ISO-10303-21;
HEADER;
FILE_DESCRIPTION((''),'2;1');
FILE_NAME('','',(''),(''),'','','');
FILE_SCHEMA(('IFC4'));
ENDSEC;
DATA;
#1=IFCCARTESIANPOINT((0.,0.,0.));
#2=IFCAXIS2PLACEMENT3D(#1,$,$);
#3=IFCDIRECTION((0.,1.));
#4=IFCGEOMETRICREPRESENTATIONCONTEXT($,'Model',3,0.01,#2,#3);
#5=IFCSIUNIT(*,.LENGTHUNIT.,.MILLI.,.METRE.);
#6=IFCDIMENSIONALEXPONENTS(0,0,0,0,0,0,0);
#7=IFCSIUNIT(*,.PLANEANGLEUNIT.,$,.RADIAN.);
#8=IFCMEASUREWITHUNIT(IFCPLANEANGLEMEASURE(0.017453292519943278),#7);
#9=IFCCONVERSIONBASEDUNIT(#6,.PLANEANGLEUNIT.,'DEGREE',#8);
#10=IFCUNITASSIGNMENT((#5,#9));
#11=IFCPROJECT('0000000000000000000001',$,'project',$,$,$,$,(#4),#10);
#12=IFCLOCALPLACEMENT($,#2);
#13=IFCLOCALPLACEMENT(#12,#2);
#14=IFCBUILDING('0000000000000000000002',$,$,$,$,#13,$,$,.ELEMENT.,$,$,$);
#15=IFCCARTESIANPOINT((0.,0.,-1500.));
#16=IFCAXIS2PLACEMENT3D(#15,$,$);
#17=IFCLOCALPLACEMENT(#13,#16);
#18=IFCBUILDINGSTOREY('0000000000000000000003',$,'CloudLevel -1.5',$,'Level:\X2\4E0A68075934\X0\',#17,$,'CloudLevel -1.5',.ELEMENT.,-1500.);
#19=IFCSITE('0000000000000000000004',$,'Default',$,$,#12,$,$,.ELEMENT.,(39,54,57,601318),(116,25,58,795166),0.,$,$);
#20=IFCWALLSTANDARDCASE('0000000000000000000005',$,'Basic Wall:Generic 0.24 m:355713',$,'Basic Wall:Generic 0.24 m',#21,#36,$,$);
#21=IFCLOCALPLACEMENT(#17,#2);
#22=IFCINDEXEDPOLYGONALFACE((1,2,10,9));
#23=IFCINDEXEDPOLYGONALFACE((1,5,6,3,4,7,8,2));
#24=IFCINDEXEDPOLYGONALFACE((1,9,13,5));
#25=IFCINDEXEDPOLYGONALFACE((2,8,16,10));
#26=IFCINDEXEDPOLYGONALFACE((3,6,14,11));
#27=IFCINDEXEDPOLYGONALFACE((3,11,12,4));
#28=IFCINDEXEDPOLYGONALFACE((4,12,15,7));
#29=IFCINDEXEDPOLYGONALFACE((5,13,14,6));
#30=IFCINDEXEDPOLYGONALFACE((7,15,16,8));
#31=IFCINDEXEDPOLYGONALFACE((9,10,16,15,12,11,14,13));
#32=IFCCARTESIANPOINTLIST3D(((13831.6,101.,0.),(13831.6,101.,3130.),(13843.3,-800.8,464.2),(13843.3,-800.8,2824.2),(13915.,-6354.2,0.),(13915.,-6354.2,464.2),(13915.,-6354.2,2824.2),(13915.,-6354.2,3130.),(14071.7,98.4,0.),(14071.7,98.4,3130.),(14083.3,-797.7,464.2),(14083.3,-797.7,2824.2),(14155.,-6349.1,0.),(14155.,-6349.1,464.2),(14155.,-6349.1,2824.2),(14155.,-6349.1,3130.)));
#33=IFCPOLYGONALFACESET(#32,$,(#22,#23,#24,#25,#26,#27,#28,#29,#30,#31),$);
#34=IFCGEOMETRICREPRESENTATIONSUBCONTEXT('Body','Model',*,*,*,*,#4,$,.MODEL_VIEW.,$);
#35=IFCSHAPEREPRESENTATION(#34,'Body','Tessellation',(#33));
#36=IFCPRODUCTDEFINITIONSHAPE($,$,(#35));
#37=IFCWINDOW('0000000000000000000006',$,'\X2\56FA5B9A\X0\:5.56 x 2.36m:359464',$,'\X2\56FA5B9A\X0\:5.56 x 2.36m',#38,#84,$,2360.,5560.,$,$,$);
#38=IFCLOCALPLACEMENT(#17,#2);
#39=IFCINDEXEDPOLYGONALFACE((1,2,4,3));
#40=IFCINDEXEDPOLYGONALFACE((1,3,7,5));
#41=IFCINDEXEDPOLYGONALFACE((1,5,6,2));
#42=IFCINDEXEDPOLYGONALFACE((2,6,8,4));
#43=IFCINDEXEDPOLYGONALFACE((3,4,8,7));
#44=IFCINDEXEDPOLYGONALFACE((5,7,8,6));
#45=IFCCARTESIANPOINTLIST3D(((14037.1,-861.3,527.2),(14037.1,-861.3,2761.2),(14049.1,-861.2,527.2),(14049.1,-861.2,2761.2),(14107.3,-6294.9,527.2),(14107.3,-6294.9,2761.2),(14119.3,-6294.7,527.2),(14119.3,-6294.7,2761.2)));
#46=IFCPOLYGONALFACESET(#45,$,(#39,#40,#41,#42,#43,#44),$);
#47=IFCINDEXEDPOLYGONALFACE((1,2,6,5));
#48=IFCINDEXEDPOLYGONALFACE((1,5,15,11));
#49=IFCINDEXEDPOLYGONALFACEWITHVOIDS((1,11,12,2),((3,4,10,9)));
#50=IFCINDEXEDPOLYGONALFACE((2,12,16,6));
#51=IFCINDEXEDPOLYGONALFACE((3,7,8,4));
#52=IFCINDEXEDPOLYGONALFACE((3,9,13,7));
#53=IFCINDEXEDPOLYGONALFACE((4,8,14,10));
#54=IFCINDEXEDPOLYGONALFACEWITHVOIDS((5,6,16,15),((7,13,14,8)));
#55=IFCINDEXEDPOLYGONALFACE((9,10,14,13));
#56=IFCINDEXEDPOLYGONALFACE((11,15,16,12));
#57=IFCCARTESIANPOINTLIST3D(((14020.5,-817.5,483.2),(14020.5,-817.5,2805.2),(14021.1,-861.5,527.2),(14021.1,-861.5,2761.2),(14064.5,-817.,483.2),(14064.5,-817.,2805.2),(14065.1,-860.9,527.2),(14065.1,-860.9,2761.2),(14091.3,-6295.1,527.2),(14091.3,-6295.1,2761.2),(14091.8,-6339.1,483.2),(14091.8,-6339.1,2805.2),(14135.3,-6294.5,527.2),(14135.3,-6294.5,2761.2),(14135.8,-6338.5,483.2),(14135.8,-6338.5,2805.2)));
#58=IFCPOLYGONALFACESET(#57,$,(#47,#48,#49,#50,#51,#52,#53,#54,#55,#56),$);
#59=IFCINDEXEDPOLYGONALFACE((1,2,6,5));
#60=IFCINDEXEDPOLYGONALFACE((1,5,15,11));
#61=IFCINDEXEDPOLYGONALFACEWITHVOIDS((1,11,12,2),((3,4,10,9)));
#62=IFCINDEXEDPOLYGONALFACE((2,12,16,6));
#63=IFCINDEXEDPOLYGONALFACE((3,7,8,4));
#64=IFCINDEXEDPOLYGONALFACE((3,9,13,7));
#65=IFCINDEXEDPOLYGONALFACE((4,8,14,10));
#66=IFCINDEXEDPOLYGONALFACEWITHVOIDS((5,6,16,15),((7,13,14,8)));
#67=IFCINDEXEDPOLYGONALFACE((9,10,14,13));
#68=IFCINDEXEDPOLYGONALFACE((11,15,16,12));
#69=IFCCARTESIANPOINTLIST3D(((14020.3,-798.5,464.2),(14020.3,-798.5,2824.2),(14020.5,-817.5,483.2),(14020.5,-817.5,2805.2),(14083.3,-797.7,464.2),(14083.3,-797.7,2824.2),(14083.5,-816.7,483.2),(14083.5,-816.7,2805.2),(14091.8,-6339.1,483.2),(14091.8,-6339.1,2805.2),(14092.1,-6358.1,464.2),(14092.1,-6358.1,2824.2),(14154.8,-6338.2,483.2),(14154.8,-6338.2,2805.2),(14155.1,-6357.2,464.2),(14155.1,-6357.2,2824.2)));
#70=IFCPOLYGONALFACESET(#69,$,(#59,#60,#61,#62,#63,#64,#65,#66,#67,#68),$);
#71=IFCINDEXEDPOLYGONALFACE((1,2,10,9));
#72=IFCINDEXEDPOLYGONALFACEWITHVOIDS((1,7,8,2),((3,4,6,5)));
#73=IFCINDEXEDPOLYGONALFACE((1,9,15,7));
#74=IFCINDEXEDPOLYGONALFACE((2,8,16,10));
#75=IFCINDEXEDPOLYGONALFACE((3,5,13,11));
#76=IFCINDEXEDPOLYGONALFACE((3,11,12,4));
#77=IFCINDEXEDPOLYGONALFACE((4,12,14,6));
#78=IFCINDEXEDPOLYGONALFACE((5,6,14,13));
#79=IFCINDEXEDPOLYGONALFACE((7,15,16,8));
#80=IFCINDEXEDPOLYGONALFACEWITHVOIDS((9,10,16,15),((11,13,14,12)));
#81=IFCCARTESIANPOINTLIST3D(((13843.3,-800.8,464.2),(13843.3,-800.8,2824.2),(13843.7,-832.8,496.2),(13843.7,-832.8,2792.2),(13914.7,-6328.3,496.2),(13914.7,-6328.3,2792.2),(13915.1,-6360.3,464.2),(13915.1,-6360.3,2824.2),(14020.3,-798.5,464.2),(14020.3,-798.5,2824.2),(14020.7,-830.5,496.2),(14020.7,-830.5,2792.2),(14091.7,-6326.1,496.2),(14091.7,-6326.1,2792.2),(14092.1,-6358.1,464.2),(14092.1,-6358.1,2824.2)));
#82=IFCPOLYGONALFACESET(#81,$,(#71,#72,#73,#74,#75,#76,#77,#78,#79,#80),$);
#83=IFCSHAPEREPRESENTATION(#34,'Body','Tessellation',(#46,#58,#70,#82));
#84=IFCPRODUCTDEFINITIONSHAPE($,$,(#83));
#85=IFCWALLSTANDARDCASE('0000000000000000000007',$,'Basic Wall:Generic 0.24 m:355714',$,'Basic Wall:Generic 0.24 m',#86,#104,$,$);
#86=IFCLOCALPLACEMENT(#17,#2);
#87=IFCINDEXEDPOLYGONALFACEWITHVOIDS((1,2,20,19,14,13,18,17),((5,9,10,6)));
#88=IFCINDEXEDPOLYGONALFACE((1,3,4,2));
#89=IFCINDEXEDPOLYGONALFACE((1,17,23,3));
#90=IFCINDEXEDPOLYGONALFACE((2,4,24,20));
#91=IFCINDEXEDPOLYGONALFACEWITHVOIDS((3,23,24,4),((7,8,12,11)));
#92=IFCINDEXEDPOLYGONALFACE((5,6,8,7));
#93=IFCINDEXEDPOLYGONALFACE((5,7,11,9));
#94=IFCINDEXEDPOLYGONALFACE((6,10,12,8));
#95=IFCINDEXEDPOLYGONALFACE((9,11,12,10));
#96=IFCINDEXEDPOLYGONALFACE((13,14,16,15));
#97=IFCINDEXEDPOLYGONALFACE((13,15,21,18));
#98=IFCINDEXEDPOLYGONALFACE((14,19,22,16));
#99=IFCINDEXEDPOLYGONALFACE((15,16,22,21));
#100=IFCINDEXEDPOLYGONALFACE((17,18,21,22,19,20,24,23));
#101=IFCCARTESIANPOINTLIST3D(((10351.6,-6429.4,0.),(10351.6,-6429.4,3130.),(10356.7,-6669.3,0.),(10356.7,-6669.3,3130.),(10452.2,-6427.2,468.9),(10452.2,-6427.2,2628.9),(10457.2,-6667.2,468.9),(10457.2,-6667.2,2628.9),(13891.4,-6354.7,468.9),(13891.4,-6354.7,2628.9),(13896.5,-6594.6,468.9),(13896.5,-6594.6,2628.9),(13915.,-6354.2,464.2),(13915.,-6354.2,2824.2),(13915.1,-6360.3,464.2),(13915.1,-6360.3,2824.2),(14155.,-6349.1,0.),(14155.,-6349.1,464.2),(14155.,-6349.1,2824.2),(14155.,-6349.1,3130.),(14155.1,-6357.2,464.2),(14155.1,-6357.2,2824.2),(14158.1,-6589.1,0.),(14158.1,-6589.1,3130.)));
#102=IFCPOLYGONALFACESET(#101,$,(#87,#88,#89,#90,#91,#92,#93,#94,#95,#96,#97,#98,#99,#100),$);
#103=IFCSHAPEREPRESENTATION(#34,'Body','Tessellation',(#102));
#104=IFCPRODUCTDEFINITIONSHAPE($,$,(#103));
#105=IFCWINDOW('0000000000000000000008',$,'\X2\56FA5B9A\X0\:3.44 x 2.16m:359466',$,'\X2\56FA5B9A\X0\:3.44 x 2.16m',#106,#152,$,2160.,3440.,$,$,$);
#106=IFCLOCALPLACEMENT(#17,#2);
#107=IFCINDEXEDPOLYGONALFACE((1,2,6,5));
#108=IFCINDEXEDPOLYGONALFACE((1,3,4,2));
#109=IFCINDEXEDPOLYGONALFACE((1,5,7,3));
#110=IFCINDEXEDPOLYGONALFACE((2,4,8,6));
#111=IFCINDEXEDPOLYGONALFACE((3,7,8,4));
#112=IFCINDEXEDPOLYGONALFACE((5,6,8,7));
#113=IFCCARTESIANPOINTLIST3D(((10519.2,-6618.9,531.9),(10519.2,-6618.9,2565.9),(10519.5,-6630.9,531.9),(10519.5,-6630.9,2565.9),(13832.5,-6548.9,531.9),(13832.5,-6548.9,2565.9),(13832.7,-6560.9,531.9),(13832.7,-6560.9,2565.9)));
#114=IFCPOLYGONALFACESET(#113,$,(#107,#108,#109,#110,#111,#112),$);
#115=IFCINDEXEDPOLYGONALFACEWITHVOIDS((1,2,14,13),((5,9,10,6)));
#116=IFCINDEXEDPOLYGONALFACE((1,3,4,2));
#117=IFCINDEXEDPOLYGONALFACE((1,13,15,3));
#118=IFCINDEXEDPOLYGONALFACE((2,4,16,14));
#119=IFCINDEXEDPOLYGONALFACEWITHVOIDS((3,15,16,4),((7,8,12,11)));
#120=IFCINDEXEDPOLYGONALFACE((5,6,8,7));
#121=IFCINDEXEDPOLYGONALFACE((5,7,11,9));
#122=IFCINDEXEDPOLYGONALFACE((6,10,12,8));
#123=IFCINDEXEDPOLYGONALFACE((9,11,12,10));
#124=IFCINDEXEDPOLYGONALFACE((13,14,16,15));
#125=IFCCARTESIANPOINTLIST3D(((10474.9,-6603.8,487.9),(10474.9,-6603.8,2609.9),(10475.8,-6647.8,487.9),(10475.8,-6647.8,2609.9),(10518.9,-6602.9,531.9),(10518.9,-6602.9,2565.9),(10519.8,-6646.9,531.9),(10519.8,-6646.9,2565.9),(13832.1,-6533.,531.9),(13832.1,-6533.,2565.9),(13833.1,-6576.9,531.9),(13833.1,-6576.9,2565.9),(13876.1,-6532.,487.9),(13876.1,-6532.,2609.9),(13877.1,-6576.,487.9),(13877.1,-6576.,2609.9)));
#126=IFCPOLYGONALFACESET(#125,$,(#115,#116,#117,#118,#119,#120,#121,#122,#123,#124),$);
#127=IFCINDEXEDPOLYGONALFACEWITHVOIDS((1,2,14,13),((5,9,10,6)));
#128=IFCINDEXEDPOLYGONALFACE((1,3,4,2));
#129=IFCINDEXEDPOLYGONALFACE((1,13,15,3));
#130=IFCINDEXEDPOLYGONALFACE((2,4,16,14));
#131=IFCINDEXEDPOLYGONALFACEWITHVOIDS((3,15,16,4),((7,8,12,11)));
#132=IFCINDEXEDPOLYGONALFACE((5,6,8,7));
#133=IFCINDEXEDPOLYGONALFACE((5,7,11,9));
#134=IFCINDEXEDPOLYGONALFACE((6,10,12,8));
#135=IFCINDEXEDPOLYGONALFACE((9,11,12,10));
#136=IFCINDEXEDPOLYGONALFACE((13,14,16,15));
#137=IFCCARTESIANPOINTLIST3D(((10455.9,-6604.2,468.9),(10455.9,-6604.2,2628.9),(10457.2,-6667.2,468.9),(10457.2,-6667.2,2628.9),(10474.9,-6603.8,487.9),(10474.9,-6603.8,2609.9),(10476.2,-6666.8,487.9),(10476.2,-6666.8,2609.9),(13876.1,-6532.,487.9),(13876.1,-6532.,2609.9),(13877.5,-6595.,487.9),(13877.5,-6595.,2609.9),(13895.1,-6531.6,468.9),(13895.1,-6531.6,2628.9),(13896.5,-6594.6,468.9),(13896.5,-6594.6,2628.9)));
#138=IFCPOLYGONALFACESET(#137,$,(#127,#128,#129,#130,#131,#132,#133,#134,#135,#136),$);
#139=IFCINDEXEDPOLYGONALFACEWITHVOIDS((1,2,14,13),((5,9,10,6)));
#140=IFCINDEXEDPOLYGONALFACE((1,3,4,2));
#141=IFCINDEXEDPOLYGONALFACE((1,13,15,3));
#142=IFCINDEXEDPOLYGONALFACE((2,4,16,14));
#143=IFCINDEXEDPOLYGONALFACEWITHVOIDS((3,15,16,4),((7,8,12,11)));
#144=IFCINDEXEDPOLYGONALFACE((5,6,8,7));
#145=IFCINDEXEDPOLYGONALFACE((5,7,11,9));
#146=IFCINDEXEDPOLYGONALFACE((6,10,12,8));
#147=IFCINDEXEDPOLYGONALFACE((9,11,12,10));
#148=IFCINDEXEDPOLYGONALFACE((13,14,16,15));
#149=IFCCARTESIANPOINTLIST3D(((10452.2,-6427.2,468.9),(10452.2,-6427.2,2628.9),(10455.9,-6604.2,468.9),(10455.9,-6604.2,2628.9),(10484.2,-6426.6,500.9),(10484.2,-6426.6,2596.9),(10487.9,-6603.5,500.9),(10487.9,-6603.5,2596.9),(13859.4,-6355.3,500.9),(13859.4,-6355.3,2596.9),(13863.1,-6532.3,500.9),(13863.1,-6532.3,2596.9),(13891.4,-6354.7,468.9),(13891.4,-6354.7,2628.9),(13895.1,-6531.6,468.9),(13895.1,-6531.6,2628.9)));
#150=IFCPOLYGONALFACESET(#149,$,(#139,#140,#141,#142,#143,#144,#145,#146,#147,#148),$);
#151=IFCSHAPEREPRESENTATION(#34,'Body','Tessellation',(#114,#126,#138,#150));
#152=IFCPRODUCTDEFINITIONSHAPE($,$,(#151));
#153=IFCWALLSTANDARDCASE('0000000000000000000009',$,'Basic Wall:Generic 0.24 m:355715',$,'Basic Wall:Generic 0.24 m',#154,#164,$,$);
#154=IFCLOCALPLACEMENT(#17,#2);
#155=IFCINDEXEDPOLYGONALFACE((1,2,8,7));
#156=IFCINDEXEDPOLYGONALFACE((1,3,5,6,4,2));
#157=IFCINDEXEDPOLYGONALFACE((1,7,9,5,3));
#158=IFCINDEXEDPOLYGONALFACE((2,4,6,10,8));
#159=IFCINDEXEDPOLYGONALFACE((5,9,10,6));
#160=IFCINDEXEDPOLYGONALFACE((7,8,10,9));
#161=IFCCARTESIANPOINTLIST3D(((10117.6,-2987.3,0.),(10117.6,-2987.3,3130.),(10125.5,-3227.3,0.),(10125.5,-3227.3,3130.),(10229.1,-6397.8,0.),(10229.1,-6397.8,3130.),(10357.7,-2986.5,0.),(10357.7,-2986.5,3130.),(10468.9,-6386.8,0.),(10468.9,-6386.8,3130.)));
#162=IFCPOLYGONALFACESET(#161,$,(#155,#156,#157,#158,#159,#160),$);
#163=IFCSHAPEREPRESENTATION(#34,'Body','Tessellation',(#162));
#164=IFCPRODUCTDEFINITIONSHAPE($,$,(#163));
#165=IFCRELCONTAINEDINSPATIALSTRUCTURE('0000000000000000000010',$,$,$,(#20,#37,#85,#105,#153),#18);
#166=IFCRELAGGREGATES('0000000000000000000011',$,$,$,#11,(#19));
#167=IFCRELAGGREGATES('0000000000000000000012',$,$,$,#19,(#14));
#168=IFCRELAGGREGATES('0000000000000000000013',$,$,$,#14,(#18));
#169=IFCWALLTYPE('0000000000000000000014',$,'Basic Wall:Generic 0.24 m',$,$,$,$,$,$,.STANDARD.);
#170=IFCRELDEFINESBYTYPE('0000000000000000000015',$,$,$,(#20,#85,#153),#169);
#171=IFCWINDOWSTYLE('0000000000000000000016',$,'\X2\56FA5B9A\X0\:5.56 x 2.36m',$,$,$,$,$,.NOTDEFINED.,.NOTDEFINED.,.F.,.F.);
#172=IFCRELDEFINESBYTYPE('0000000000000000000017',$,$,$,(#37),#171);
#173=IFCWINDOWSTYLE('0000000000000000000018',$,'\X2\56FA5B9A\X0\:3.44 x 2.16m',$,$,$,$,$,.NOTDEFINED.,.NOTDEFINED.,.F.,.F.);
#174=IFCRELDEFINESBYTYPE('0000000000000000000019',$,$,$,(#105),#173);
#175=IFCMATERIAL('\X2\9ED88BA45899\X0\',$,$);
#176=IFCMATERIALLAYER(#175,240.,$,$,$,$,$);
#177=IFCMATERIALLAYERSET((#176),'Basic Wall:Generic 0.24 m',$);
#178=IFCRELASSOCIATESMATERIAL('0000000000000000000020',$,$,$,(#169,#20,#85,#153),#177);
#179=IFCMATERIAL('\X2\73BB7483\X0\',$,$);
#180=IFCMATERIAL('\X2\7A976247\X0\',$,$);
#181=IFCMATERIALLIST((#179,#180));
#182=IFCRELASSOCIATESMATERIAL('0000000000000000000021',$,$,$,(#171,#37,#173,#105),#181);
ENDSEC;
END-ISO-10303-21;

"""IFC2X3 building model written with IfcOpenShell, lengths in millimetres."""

from ifc_helpers import new_model, entity, si_unit, converted_unit, direction, frame, frame_2d, origin, place, context, subcontext, project, spatial, polyline, rectangle, outline, extrude, source, transform, mapped, material, material_list, layer, layer_set, layer_usage, type_object, type_shapes, element, fill, save


model = new_model("IFC2X3")

# Units and contexts
model_context = context("Model", 3, precision=0.01, world=origin(), true_north=direction((0.0, 1.0)))
body_context = subcontext(model_context, "Body", "Model", "MODEL_VIEW")
ifc_project = project(units=[si_unit("LENGTHUNIT", "METRE", prefix="MILLI"), converted_unit("PLANEANGLEUNIT", "DEGREE", entity("IfcPlaneAngleMeasure", 0.017453292519943278), si_unit("PLANEANGLEUNIT", "RADIAN"), dimensions=[0, 0, 0, 0, 0, 0, 0])], contexts=[model_context])

# Site, building, storey
site_placement = place(None, origin())
site = spatial("IfcSite", under=ifc_project, at=site_placement, Name="Default", CompositionType="ELEMENT", RefLatitude=(39, 54, 57, 601318), RefLongitude=(116, 25, 58, 795166), RefElevation=0.0)
building_placement = place(site_placement, origin())
building = spatial("IfcBuilding", under=site, at=building_placement, CompositionType="ELEMENT")
storey_placement = place(building_placement, frame((0.0, 0.0, -1500.0)))
storey = spatial("IfcBuildingStorey", under=building, at=storey_placement, Name="CloudLevel -1.5", ObjectType="Level:上标头", LongName="CloudLevel -1.5", CompositionType="ELEMENT", Elevation=-1500.0)

# Shared definitions
ifc_material_1 = material(Name="默认墙")
ifc_layer_1 = layer(ifc_material_1, 240.0)
ifc_layer_set_1 = layer_set([ifc_layer_1], Name="Basic Wall:Generic 0.24 m")
ifc_layer_usage_1 = layer_usage(ifc_layer_set_1, "AXIS2", "NEGATIVE", 120.0)
wall_type_1 = type_object("IfcWallType", Name="Basic Wall:Generic 0.24 m", PredefinedType="STANDARD", material=ifc_layer_set_1)

# Shared definitions
ifc_material_2 = material(Name="玻璃")

# Wall, opening, window
wall_1_placement = place(storey_placement, frame((14035.0, -6352.6, 0.0), z_axis=(0.0, 0.0, 1.0), x_axis=(-0.012912, 0.999917, 0.0)))
wall_1 = element("IfcWallStandardCase", 1, at=wall_1_placement, inside=storey, type_object=wall_type_1, material=ifc_layer_usage_1, Name="Basic Wall:Generic 0.24 m:355713", ObjectType="Basic Wall:Generic 0.24 m", context=body_context, shape_type="SweptSolid", body=[
    extrude(outline(polyline([(6450.0, -120.0), (6455.7, 120.0), (6215.7, 120.0), (0.0, 120.0), (2.0, -120.0), (6450.0, -120.0)])), origin(), (0.0, 0.0, 1.0), 3130.0),
])
opening_1_placement = place(wall_1_placement, frame((5553.8, 120.0, 464.2)))
opening_1 = element("IfcOpeningElement", 2, at=opening_1_placement, cuts=wall_1, ObjectType="Opening", context=body_context, shape_type="SweptSolid", body=[
    extrude(rectangle(XDim=2360.0, YDim=5560.0, at=frame_2d((1180.0, 2780.0), x_axis=(1.0, 0.0))), frame((0.0, 0.0, 0.0), z_axis=(0.0, -1.0, 0.0), x_axis=(0.0, 0.0, 1.0)), (0.0, 0.0, 1.0), 240.0),
])
ifc_material_3 = material(Name="窗扇")
ifc_material_list_1 = material_list([ifc_material_2, ifc_material_3])
window_style_1 = type_object("IfcWindowStyle", Name="固定:5.56 x 2.36m", ConstructionType="NOTDEFINED", OperationType="NOTDEFINED", ParameterTakesPrecedence=False, Sizeable=False, material=ifc_material_list_1)
shared_shape_1 = source(origin(), body_context, "Body", "SweptSolid", [
    extrude(rectangle(XDim=5434.0, YDim=12.0, at=frame_2d((0.0, 0.0), x_axis=(1.0, 0.0))), frame((2780.0, 225.0, 63.0), z_axis=(0.0, 0.0, 1.0), x_axis=(-1.0, 0.0, 0.0)), (0.0, 0.0, 1.0), 2234.0),
    extrude(outline(polyline([(-2761.0, -1161.0), (2761.0, -1161.0), (2761.0, 1161.0), (-2761.0, 1161.0), (-2761.0, -1161.0)]), holes=[polyline([(-2717.0, -1117.0), (-2717.0, 1117.0), (2717.0, 1117.0), (2717.0, -1117.0), (-2717.0, -1117.0)])]), frame((2780.0, 247.0, 1180.0), z_axis=(0.0, -1.0, 0.0), x_axis=(-1.0, 0.0, 0.0)), (0.0, 0.0, 1.0), 44.0),
    extrude(outline(polyline([(-2780.0, -1180.0), (2780.0, -1180.0), (2780.0, 1180.0), (-2780.0, 1180.0), (-2780.0, -1180.0)]), holes=[polyline([(-2761.0, -1161.0), (-2761.0, 1161.0), (2761.0, 1161.0), (2761.0, -1161.0), (-2761.0, -1161.0)])]), frame((2780.0, 266.0, 1180.0), z_axis=(0.0, -1.0, 0.0), x_axis=(-1.0, 0.0, 0.0)), (0.0, 0.0, 1.0), 63.0),
    extrude(outline(polyline([(-2780.0, -1180.0), (2780.0, -1180.0), (2780.0, 1180.0), (-2780.0, 1180.0), (-2780.0, -1180.0)]), holes=[polyline([(-2748.0, -1148.0), (-2748.0, 1148.0), (2748.0, 1148.0), (2748.0, -1148.0), (-2748.0, -1148.0)])]), frame((2780.0, 203.0, 1180.0), z_axis=(0.0, -1.0, 0.0), x_axis=(-1.0, 0.0, 0.0)), (0.0, 0.0, 1.0), 177.0),
])
type_shapes(window_style_1, [shared_shape_1])
window_1_placement = place(opening_1_placement, frame((0.0, 26.0, 0.0), z_axis=(0.0, 0.0, 1.0), x_axis=(-1.0, 0.0, 0.0)))
window_1 = element("IfcWindow", 3, at=window_1_placement, inside=storey, type_object=window_style_1, material=ifc_material_list_1, Name="固定:5.56 x 2.36m:359464", ObjectType="固定:5.56 x 2.36m", OverallHeight=2360.0, OverallWidth=5560.0, context=body_context, shape_type="MappedRepresentation", body=[
    mapped(shared_shape_1, transform((0.0, 0.0, 0.0), scale=1.0)),
])
fill(opening_1, window_1)

# Wall, openings, window
wall_2_placement = place(storey_placement, frame((10354.1, -6549.3, 0.0), z_axis=(0.0, 0.0, 1.0), x_axis=(0.999777, 0.0211, 0.0)))
wall_2 = element("IfcWallStandardCase", 4, at=wall_2_placement, inside=storey, type_object=wall_type_1, material=ifc_layer_usage_1, Name="Basic Wall:Generic 0.24 m:355714", ObjectType="Basic Wall:Generic 0.24 m", context=body_context, shape_type="SweptSolid", body=[
    extrude(outline(polyline([(3802.2, -120.0), (3804.2, 120.0), (3564.2, 120.0), (118.6, 120.0), (0.0, 120.0), (0.0, -82.9), (0.0, -120.0), (3802.2, -120.0)])), origin(), (0.0, 0.0, 1.0), 3130.0),
])
opening_2_placement = place(wall_2_placement, origin())
element("IfcOpeningElement", 5, at=opening_2_placement, cuts=wall_2, ObjectType="Opening", context=body_context, shape_type="SweptSolid", body=[
    extrude(rectangle(XDim=2360.0, YDim=240.0, at=frame_2d((0.0, 0.0), x_axis=(0.0, 1.0))), frame((3684.1, 112.8, 1644.2), z_axis=(0.008189, 0.999966, 0.0), x_axis=(0.999966, -0.008189, 0.0)), (0.0, 0.0, 1.0), 5560.0),
])
opening_3_placement = place(wall_2_placement, frame((3540.6, 120.0, 468.9)))
opening_3 = element("IfcOpeningElement", 6, at=opening_3_placement, cuts=wall_2, ObjectType="Opening", context=body_context, shape_type="SweptSolid", body=[
    extrude(rectangle(XDim=2160.0, YDim=3440.0, at=frame_2d((1080.0, 1720.0), x_axis=(1.0, 0.0))), frame((0.0, 0.0, 0.0), z_axis=(0.0, -1.0, 0.0), x_axis=(0.0, 0.0, 1.0)), (0.0, 0.0, 1.0), 240.0),
])
window_style_2 = type_object("IfcWindowStyle", Name="固定:3.44 x 2.16m", ConstructionType="NOTDEFINED", OperationType="NOTDEFINED", ParameterTakesPrecedence=False, Sizeable=False, material=ifc_material_list_1)
shared_shape_2 = source(origin(), body_context, "Body", "SweptSolid", [
    extrude(rectangle(XDim=3314.0, YDim=12.0, at=frame_2d((0.0, 0.0), x_axis=(1.0, 0.0))), frame((1720.0, 225.0, 63.0), z_axis=(0.0, 0.0, 1.0), x_axis=(-1.0, 0.0, 0.0)), (0.0, 0.0, 1.0), 2034.0),
    extrude(outline(polyline([(-1701.0, -1061.0), (1701.0, -1061.0), (1701.0, 1061.0), (-1701.0, 1061.0), (-1701.0, -1061.0)]), holes=[polyline([(-1657.0, -1017.0), (-1657.0, 1017.0), (1657.0, 1017.0), (1657.0, -1017.0), (-1657.0, -1017.0)])]), frame((1720.0, 247.0, 1080.0), z_axis=(0.0, -1.0, 0.0), x_axis=(-1.0, 0.0, 0.0)), (0.0, 0.0, 1.0), 44.0),
    extrude(outline(polyline([(-1720.0, -1080.0), (1720.0, -1080.0), (1720.0, 1080.0), (-1720.0, 1080.0), (-1720.0, -1080.0)]), holes=[polyline([(-1701.0, -1061.0), (-1701.0, 1061.0), (1701.0, 1061.0), (1701.0, -1061.0), (-1701.0, -1061.0)])]), frame((1720.0, 266.0, 1080.0), z_axis=(0.0, -1.0, 0.0), x_axis=(-1.0, 0.0, 0.0)), (0.0, 0.0, 1.0), 63.0),
    extrude(outline(polyline([(-1720.0, -1080.0), (1720.0, -1080.0), (1720.0, 1080.0), (-1720.0, 1080.0), (-1720.0, -1080.0)]), holes=[polyline([(-1688.0, -1048.0), (-1688.0, 1048.0), (1688.0, 1048.0), (1688.0, -1048.0), (-1688.0, -1048.0)])]), frame((1720.0, 203.0, 1080.0), z_axis=(0.0, -1.0, 0.0), x_axis=(-1.0, 0.0, 0.0)), (0.0, 0.0, 1.0), 177.0),
])
type_shapes(window_style_2, [shared_shape_2])
window_2_placement = place(opening_3_placement, frame((0.0, 26.0, 0.0), z_axis=(0.0, 0.0, 1.0), x_axis=(-1.0, 0.0, 0.0)))
window_2 = element("IfcWindow", 7, at=window_2_placement, inside=storey, type_object=window_style_2, material=ifc_material_list_1, Name="固定:3.44 x 2.16m:359466", ObjectType="固定:3.44 x 2.16m", OverallHeight=2160.0, OverallWidth=3440.0, context=body_context, shape_type="MappedRepresentation", body=[
    mapped(shared_shape_2, transform((0.0, 0.0, 0.0), scale=1.0)),
])
fill(opening_3, window_2)

# Wall
wall_3_placement = place(storey_placement, frame((10349.1, -6393.9, 0.0), z_axis=(0.0, 0.0, 1.0), x_axis=(-0.032678, 0.999466, 0.0)))
element("IfcWallStandardCase", 8, at=wall_3_placement, inside=storey, type_object=wall_type_1, material=ifc_layer_usage_1, Name="Basic Wall:Generic 0.24 m:355715", ObjectType="Basic Wall:Generic 0.24 m", context=body_context, shape_type="SweptSolid", body=[
    extrude(outline(polyline([(3405.3, -120.0), (3412.3, 120.0), (3172.2, 120.0), (0.0, 120.0), (3.1, -120.0), (3405.3, -120.0)])), origin(), (0.0, 0.0, 1.0), 3130.0),
])

save(model, "model.ifc")
